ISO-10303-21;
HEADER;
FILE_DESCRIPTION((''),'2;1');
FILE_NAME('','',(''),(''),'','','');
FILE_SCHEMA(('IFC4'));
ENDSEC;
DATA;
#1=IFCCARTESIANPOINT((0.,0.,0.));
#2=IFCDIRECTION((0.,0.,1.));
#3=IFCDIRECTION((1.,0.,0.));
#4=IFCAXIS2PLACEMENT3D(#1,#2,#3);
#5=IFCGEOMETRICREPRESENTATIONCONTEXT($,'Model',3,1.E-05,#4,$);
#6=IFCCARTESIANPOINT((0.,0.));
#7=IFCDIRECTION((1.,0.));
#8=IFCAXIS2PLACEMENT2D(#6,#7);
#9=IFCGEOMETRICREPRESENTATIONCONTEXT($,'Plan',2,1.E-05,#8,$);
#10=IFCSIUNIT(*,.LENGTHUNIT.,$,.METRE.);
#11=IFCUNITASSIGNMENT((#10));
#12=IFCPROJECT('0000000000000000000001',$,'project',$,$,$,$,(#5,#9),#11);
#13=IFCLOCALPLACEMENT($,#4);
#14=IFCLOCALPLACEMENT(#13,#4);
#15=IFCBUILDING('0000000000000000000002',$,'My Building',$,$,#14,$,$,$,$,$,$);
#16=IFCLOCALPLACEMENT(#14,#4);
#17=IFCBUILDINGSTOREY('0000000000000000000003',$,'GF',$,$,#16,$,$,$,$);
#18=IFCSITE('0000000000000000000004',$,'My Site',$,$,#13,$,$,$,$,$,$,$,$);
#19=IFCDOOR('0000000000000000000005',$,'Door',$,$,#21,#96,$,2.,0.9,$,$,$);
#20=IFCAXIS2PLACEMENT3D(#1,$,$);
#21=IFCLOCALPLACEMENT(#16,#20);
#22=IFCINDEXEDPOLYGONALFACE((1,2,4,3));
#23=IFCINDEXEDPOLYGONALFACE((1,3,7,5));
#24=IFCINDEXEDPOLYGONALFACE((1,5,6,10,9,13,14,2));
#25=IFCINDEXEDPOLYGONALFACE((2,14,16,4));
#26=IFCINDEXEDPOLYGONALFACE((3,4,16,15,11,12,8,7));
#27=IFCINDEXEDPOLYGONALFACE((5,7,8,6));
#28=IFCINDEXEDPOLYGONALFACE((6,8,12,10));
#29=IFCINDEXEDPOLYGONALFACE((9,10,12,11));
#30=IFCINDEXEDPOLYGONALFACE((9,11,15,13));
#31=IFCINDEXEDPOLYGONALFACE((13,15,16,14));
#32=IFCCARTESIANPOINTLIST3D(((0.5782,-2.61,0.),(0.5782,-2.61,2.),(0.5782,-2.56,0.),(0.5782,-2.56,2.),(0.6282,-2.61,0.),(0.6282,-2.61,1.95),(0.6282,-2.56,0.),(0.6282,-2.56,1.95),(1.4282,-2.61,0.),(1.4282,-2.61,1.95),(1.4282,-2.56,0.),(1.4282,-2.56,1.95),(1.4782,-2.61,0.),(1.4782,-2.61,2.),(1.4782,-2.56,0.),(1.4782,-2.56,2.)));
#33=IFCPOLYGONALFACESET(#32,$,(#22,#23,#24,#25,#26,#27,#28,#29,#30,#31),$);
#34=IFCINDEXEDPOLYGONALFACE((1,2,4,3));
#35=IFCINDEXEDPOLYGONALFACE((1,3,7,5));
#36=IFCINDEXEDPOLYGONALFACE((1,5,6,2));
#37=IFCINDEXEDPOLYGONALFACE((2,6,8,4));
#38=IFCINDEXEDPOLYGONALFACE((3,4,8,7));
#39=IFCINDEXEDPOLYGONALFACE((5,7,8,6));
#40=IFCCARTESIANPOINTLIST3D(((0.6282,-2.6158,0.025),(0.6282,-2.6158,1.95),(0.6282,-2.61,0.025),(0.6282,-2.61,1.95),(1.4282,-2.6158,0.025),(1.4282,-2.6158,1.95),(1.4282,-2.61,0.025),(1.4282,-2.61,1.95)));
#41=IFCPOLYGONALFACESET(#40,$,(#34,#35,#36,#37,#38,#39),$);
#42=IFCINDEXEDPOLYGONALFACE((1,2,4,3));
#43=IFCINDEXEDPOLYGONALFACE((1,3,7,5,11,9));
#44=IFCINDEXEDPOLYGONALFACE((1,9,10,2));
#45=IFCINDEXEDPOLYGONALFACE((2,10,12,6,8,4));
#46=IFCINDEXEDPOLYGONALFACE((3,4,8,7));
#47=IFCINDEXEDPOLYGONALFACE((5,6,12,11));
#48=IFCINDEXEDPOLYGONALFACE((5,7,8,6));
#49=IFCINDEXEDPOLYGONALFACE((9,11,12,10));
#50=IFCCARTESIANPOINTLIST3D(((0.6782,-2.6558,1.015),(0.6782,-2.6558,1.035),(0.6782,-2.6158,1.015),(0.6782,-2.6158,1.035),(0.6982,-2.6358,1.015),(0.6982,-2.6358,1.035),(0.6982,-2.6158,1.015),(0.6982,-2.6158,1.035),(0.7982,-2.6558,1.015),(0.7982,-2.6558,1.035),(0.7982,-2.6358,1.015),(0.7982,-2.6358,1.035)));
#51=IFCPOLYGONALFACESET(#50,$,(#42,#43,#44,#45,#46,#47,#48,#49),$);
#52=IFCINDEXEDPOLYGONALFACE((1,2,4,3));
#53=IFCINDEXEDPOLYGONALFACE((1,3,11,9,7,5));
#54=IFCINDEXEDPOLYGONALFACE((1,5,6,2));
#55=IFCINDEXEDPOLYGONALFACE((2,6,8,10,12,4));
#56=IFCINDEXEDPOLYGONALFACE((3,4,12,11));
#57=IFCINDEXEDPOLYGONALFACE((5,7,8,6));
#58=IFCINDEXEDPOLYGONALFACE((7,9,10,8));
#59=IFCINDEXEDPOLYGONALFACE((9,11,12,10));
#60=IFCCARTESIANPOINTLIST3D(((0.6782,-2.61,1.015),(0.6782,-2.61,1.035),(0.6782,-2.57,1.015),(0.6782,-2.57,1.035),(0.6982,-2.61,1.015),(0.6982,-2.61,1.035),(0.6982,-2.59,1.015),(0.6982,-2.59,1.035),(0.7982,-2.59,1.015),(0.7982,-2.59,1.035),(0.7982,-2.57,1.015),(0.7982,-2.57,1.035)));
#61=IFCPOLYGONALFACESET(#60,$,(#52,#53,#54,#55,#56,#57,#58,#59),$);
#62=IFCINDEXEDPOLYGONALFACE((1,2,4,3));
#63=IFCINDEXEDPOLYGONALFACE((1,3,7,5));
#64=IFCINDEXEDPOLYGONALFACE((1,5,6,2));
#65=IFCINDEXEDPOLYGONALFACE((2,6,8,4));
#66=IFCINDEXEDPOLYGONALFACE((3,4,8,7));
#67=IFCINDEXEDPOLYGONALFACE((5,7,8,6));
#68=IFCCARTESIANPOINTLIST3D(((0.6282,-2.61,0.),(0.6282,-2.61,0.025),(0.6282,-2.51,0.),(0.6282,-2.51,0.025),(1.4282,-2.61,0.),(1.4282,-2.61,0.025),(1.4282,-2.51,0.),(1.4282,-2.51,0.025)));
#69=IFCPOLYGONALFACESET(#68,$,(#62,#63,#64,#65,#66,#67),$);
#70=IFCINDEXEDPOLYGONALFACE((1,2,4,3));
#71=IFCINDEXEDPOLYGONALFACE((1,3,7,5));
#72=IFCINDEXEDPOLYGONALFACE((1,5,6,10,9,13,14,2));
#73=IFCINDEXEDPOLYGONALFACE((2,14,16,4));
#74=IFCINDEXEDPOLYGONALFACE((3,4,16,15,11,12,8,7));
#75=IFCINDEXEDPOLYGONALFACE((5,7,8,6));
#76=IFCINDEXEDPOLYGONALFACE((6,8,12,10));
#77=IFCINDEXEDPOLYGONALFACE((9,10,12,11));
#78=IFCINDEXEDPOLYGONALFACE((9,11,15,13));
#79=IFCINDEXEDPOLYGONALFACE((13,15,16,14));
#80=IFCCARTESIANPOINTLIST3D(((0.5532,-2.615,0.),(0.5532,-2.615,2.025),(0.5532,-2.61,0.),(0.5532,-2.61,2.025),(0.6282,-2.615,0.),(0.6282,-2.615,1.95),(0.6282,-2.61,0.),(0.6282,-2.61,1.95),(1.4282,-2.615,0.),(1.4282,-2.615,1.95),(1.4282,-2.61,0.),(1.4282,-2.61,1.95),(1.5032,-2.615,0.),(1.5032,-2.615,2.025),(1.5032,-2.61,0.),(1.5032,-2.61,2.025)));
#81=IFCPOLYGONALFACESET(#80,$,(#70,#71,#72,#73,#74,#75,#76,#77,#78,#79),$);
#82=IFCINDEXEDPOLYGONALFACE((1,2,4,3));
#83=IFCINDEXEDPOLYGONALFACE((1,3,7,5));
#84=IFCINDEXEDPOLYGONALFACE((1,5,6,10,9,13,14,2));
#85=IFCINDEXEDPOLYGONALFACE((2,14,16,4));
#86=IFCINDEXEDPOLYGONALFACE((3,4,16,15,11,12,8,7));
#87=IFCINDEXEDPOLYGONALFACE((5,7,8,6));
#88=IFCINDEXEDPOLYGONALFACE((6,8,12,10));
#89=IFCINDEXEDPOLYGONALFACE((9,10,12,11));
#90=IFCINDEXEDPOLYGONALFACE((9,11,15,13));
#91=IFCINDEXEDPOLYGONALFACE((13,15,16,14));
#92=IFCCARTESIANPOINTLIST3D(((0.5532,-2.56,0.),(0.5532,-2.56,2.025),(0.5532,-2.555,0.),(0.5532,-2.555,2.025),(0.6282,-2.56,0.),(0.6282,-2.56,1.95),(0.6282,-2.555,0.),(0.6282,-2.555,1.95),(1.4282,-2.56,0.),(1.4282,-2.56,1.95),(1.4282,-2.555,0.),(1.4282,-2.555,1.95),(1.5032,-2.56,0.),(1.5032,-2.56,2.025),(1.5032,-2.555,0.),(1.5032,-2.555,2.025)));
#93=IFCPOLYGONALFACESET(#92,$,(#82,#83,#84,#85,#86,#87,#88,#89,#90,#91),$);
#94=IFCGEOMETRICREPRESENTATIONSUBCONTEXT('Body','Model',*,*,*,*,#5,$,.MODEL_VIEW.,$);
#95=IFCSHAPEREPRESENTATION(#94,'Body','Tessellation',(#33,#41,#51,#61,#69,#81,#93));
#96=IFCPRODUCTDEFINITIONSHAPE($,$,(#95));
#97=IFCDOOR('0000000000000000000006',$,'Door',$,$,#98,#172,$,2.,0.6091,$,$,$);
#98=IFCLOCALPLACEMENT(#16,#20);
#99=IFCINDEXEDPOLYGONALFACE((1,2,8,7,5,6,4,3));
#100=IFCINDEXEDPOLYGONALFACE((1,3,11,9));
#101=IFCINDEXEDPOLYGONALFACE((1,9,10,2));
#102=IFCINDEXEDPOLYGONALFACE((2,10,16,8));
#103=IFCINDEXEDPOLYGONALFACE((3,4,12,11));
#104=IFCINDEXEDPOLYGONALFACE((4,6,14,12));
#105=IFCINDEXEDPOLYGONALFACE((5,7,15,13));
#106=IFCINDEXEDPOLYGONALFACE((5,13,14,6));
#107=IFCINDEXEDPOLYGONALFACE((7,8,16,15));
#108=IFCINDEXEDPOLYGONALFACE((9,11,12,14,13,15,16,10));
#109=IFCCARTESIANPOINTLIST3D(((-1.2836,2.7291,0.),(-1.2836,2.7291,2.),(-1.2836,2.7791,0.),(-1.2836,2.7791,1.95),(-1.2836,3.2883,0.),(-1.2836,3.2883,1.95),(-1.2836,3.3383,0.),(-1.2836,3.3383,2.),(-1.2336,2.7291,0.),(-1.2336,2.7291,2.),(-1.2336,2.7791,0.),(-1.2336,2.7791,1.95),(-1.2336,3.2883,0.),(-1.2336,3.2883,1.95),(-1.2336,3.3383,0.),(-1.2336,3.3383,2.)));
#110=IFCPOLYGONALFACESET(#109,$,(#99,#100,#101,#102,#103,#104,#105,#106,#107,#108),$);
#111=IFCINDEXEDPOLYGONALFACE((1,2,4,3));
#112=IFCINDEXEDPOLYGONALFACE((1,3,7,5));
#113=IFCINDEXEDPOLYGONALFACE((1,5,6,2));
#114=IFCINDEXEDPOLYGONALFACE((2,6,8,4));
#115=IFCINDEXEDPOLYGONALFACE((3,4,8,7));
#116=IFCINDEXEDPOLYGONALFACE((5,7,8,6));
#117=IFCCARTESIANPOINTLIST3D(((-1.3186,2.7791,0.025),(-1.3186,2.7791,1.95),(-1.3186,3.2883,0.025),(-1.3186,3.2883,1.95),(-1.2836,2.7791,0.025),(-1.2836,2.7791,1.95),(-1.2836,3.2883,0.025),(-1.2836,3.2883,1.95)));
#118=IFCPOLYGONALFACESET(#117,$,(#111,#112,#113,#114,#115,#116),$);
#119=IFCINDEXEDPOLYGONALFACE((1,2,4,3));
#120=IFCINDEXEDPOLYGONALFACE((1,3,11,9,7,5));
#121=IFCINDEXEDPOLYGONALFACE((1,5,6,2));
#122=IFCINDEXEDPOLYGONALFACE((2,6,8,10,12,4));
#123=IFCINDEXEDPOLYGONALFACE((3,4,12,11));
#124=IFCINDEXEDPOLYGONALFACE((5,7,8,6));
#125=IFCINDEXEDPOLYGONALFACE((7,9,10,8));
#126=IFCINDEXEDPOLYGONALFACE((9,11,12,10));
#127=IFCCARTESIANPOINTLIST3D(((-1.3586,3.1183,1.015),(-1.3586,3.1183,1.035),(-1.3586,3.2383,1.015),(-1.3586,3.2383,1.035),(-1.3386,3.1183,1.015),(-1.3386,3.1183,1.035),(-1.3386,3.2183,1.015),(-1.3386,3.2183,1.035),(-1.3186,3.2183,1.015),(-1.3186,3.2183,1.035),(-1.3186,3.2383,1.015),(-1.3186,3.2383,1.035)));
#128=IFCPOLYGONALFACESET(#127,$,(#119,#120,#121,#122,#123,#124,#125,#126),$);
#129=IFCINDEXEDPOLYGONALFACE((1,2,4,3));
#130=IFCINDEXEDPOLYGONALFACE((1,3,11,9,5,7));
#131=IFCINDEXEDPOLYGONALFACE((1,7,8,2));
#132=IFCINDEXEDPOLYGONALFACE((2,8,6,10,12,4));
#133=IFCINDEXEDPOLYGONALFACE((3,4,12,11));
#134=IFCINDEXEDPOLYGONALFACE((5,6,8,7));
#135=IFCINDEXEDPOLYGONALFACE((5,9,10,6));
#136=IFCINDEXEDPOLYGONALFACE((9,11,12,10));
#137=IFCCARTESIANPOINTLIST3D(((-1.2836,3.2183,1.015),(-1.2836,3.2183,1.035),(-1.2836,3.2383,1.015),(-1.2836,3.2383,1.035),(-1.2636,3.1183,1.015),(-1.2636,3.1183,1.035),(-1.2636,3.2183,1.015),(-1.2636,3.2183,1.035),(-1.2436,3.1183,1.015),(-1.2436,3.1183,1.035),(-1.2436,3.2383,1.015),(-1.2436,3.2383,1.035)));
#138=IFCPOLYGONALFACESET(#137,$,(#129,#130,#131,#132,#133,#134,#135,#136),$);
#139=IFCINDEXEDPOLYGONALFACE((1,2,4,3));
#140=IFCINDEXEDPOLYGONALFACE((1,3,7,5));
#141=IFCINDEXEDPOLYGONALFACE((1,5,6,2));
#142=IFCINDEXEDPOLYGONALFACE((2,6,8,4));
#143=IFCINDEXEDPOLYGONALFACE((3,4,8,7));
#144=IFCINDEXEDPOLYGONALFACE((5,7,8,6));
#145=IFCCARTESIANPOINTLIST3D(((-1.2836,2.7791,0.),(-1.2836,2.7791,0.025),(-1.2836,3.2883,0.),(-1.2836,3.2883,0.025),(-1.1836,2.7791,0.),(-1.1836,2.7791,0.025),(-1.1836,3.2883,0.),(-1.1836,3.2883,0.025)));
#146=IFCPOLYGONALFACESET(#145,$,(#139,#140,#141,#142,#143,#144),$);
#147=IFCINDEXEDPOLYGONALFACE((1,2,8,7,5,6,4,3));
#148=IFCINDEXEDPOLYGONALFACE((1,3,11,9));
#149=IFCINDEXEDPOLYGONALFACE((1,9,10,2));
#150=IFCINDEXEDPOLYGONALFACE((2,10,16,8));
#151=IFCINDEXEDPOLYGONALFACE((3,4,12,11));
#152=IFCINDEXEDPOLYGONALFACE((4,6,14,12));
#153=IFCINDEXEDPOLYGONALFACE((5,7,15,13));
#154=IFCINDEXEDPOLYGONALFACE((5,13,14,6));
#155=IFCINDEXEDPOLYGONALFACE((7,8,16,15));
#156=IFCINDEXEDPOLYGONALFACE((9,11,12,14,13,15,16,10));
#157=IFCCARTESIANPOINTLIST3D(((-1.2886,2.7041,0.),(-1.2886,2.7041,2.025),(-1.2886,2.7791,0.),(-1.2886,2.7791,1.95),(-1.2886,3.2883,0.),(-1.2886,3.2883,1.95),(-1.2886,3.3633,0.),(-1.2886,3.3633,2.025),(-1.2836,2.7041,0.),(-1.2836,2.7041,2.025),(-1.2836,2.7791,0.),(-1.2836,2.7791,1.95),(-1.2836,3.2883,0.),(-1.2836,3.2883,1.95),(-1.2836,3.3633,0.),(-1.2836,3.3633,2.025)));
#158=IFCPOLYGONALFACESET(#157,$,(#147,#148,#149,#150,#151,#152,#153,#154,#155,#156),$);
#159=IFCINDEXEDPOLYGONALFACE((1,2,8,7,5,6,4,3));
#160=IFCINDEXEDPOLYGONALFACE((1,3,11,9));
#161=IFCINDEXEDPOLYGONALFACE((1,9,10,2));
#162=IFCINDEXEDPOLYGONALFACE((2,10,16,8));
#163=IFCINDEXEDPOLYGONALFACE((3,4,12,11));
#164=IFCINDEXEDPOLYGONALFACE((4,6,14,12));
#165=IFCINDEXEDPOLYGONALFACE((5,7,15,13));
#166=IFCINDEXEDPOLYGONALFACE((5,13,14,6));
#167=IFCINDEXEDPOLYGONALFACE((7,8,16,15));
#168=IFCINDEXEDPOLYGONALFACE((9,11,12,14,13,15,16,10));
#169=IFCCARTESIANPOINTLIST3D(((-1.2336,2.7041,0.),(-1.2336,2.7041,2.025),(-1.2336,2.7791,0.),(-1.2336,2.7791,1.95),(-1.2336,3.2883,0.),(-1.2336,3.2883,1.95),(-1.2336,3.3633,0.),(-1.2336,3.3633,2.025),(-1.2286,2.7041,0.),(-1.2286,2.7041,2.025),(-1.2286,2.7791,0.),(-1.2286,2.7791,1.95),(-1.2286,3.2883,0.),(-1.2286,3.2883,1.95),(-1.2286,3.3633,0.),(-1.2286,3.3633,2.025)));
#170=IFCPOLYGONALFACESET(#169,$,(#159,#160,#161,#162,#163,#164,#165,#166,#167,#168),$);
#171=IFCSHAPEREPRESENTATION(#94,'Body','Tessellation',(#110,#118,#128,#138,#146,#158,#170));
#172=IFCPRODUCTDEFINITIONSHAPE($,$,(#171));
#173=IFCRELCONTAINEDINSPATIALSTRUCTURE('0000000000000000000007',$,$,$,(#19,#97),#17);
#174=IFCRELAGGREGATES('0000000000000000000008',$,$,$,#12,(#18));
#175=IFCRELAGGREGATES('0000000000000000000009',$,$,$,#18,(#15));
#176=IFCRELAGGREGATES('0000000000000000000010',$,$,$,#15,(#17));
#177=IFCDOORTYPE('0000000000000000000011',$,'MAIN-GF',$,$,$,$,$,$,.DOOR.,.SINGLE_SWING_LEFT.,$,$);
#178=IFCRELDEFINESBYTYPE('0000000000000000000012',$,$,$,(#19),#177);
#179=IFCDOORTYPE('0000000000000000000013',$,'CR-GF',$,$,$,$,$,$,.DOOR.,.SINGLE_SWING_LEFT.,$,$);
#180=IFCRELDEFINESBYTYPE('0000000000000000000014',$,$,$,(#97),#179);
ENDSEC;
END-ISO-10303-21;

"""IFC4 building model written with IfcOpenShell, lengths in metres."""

from ifc_helpers import new_model, entity, si_unit, frame, origin_with_axes, origin_2d_with_axis, place, context, subcontext, project, spatial, line, indexed_curve, outline, extrude, shape, source, transform, mapped, type_object, type_shapes, element, save


model = new_model("IFC4")

# Units and contexts
model_context = context("Model", 3, precision=1e-05, world=origin_with_axes())
plan_context = context("Plan", 2, precision=1e-05, world=origin_2d_with_axis())
body_context_1 = subcontext(model_context, "Body", "Model", "MODEL_VIEW")
body_context_2 = subcontext(plan_context, "Body", "Plan", "PLAN_VIEW")
ifc_project = project(units=[si_unit("LENGTHUNIT", "METRE")], contexts=[model_context, plan_context])

# Site, building, storey
site_placement = place(None, origin_with_axes())
site = spatial("IfcSite", under=ifc_project, at=site_placement, Name="My Site")
building_placement = place(site_placement, origin_with_axes())
building = spatial("IfcBuilding", under=site, at=building_placement, Name="My Building")
storey_placement = place(building_placement, origin_with_axes())
storey = spatial("IfcBuildingStorey", under=building, at=storey_placement, Name="GF")

# Shared definitions
wall_1_placement = place(storey_placement, frame((0.2283, -2.61, 0.0), z_axis=(0.0, 0.0, 1.0), x_axis=(1.0, 0.0, 0.0)))
door_type_1 = type_object("IfcDoorType", Name="MAIN-GF", OperationType="SINGLE_SWING_LEFT", PredefinedType="DOOR")
shared_shape_1 = source(origin_with_axes(), body_context_1, "Body", "SweptSolid", [
    extrude(outline(indexed_curve([(0.0, 0.0), (0.0, 2.0), (0.9, 2.0), (0.9, 0.0), (0.85, 0.0), (0.85, 1.95), (0.05, 1.95), (0.05, 0.0)], segments=[line(1, 2, 3, 4, 5, 6, 7, 8, 1)])), frame((0.0, 0.0, 0.0), z_axis=(0.0, -1.0, 0.0), x_axis=(1.0, 0.0, 0.0)), (0.0, 0.0, -1.0), 0.05),
    extrude(outline(indexed_curve([(0.0, 0.0), (0.8, 0.0), (0.8, 0.0058), (0.0, 0.0058)], segments=[line(1, 2, 3, 4, 1)])), frame((0.05, -0.0058, 0.025), z_axis=(0.0, 0.0, 1.0), x_axis=(1.0, 0.0, 0.0)), (0.0, 0.0, 1.0), 1.925),
    extrude(outline(indexed_curve([(0.0, 0.0), (0.0, -0.04), (0.12, -0.04), (0.12, -0.02), (0.02, -0.02), (0.02, 0.0)], segments=[line(1, 2, 3, 4, 5, 6, 1)])), frame((0.1, -0.0058, 1.015), z_axis=(0.0, 0.0, 1.0), x_axis=(1.0, 0.0, 0.0)), (0.0, 0.0, 1.0), 0.02),
    extrude(outline(indexed_curve([(0.0, 0.0), (0.0, 0.04), (0.12, 0.04), (0.12, 0.02), (0.02, 0.02), (0.02, 0.0)], segments=[line(1, 2, 3, 4, 5, 6, 1)])), frame((0.1, 0.0, 1.015), z_axis=(0.0, 0.0, 1.0), x_axis=(1.0, 0.0, 0.0)), (0.0, 0.0, 1.0), 0.02),
    extrude(outline(indexed_curve([(0.0, 0.0), (0.8, 0.0), (0.8, 0.1), (0.0, 0.1)], segments=[line(1, 2, 3, 4, 1)])), frame((0.05, 0.0, 0.0), z_axis=(0.0, 0.0, 1.0), x_axis=(1.0, 0.0, 0.0)), (0.0, 0.0, 1.0), 0.025),
    extrude(outline(indexed_curve([(0.0, 0.0), (0.0, 2.025), (0.95, 2.025), (0.95, 0.0), (0.875, 0.0), (0.875, 1.95), (0.075, 1.95), (0.075, 0.0)], segments=[line(1, 2, 3, 4, 5, 6, 7, 8, 1)])), frame((-0.025, -0.005, 0.0), z_axis=(0.0, -1.0, 0.0), x_axis=(1.0, 0.0, 0.0)), (0.0, 0.0, -1.0), 0.005),
    extrude(outline(indexed_curve([(0.0, 0.0), (0.0, 2.025), (0.95, 2.025), (0.95, 0.0), (0.875, 0.0), (0.875, 1.95), (0.075, 1.95), (0.075, 0.0)], segments=[line(1, 2, 3, 4, 5, 6, 7, 8, 1)])), frame((-0.025, 0.05, 0.0), z_axis=(0.0, -1.0, 0.0), x_axis=(1.0, 0.0, 0.0)), (0.0, 0.0, -1.0), 0.005),
])
shared_shape_2 = source(origin_with_axes(), body_context_2, "Body", "Curve2D", [
    entity("IfcIndexedPolyCurve", entity("IfcCartesianPointList2D", [[0.0, 0.0], [0.05, 0.0], [0.05, 0.05], [0.0, 0.05]]), [entity("IfcLineIndex", [1, 2, 3, 4, 1])]),
    entity("IfcIndexedPolyCurve", entity("IfcCartesianPointList2D", [[0.9, 0.0], [0.85, 0.0], [0.85, 0.05], [0.9, 0.05]]), [entity("IfcLineIndex", [1, 2, 3, 4, 1])]),
    entity("IfcIndexedPolyCurve", entity("IfcCartesianPointList2D", [[1.25, -0.0058], [0.45, -0.0058], [0.45, 0.0], [1.25, 0.0]]), [entity("IfcLineIndex", [1, 2, 3, 4, 1])]),
])
type_shapes(door_type_1, [shared_shape_1, shared_shape_2])

# Shared definitions
wall_2_placement = place(storey_placement, frame((-1.1836, 2.64, 0.0), z_axis=(0.0, 0.0, 1.0), x_axis=(0.0, 1.0, 0.0)))
door_type_2 = type_object("IfcDoorType", Name="CR-GF", OperationType="SINGLE_SWING_LEFT", PredefinedType="DOOR")
shared_shape_3 = source(origin_with_axes(), body_context_1, "Body", "SweptSolid", [
    extrude(outline(indexed_curve([(0.0, 0.0), (0.0, 2.0), (0.6091, 2.0), (0.6091, 0.0), (0.5591, 0.0), (0.5591, 1.95), (0.05, 1.95), (0.05, 0.0)], segments=[line(1, 2, 3, 4, 5, 6, 7, 8, 1)])), frame((0.0, 0.0, 0.0), z_axis=(0.0, -1.0, 0.0), x_axis=(1.0, 0.0, 0.0)), (0.0, 0.0, -1.0), 0.05),
    extrude(outline(indexed_curve([(0.0, 0.0), (0.5091, 0.0), (0.5091, 0.035), (0.0, 0.035)], segments=[line(1, 2, 3, 4, 1)])), frame((0.05, -0.035, 0.025), z_axis=(0.0, 0.0, 1.0), x_axis=(1.0, 0.0, 0.0)), (0.0, 0.0, 1.0), 1.925),
    extrude(outline(indexed_curve([(0.0, 0.0), (0.0, -0.04), (0.12, -0.04), (0.12, -0.02), (0.02, -0.02), (0.02, 0.0)], segments=[line(1, 2, 3, 4, 5, 6, 1)])), frame((0.1, -0.035, 1.015), z_axis=(0.0, 0.0, 1.0), x_axis=(1.0, 0.0, 0.0)), (0.0, 0.0, 1.0), 0.02),
    extrude(outline(indexed_curve([(0.0, 0.0), (0.0, 0.04), (0.12, 0.04), (0.12, 0.02), (0.02, 0.02), (0.02, 0.0)], segments=[line(1, 2, 3, 4, 5, 6, 1)])), frame((0.1, 0.0, 1.015), z_axis=(0.0, 0.0, 1.0), x_axis=(1.0, 0.0, 0.0)), (0.0, 0.0, 1.0), 0.02),
    extrude(outline(indexed_curve([(0.0, 0.0), (0.5091, 0.0), (0.5091, 0.1), (0.0, 0.1)], segments=[line(1, 2, 3, 4, 1)])), frame((0.05, 0.0, 0.0), z_axis=(0.0, 0.0, 1.0), x_axis=(1.0, 0.0, 0.0)), (0.0, 0.0, 1.0), 0.025),
    extrude(outline(indexed_curve([(0.0, 0.0), (0.0, 2.025), (0.6591, 2.025), (0.6591, 0.0), (0.5841, 0.0), (0.5841, 1.95), (0.075, 1.95), (0.075, 0.0)], segments=[line(1, 2, 3, 4, 5, 6, 7, 8, 1)])), frame((-0.025, -0.005, 0.0), z_axis=(0.0, -1.0, 0.0), x_axis=(1.0, 0.0, 0.0)), (0.0, 0.0, -1.0), 0.005),
    extrude(outline(indexed_curve([(0.0, 0.0), (0.0, 2.025), (0.6591, 2.025), (0.6591, 0.0), (0.5841, 0.0), (0.5841, 1.95), (0.075, 1.95), (0.075, 0.0)], segments=[line(1, 2, 3, 4, 5, 6, 7, 8, 1)])), frame((-0.025, 0.05, 0.0), z_axis=(0.0, -1.0, 0.0), x_axis=(1.0, 0.0, 0.0)), (0.0, 0.0, -1.0), 0.005),
])
shared_shape_4 = source(origin_with_axes(), body_context_2, "Body", "Curve2D", [
    entity("IfcIndexedPolyCurve", entity("IfcCartesianPointList2D", [[0.0, 0.0], [0.05, 0.0], [0.05, 0.05], [0.0, 0.05]]), [entity("IfcLineIndex", [1, 2, 3, 4, 1])]),
    entity("IfcIndexedPolyCurve", entity("IfcCartesianPointList2D", [[0.6091, 0.0], [0.5591, 0.0], [0.5591, 0.05], [0.6091, 0.05]]), [entity("IfcLineIndex", [1, 2, 3, 4, 1])]),
    entity("IfcIndexedPolyCurve", entity("IfcCartesianPointList2D", [[0.8137, -0.035], [0.3046, -0.035], [0.3046, 0.0], [0.8137, 0.0]]), [entity("IfcLineIndex", [1, 2, 3, 4, 1])]),
])
type_shapes(door_type_2, [shared_shape_3, shared_shape_4])

# Doors
placement_1 = place(wall_1_placement, frame((0.3499, 0.0, 0.0), z_axis=(0.0, 0.0, 1.0), x_axis=(1.0, 0.0, 0.0)))
door_1_placement = place(placement_1, origin_with_axes())
element("IfcDoor", 1, at=door_1_placement, inside=storey, type_object=door_type_1, Name="Door", OverallHeight=2.0, OverallWidth=0.9, shapes=[
    shape(body_context_1, "Body", "MappedRepresentation", [mapped(shared_shape_1, transform((0.0, 0.0, 0.0), x_axis=(1.0, 0.0, 0.0), y_axis=(0.0, 1.0, 0.0), z_axis=(0.0, 0.0, 1.0), scale=1.0))]),
    shape(body_context_2, "Body", "MappedRepresentation", [mapped(shared_shape_2, transform((0.0, 0.0, 0.0), x_axis=(1.0, 0.0, 0.0), y_axis=(0.0, 1.0, 0.0), z_axis=(0.0, 0.0, 1.0), scale=1.0))]),
])
placement_2 = place(wall_2_placement, frame((0.6983, 0.1, 0.0), z_axis=(0.0, 0.0, 1.0), x_axis=(-1.0, 0.0, 0.0)))
door_2_placement = place(placement_2, frame((0.0, 0.0, 0.0), z_axis=(0.0, 0.0, 1.0), x_axis=(1.0, 0.0, 0.0)))
element("IfcDoor", 2, at=door_2_placement, inside=storey, type_object=door_type_2, Name="Door", OverallHeight=2.0, OverallWidth=0.6091, shapes=[
    shape(body_context_1, "Body", "MappedRepresentation", [mapped(shared_shape_3, transform((0.0, 0.0, 0.0), x_axis=(1.0, 0.0, 0.0), y_axis=(0.0, 1.0, 0.0), z_axis=(0.0, 0.0, 1.0), scale=1.0))]),
    shape(body_context_2, "Body", "MappedRepresentation", [mapped(shared_shape_4, transform((0.0, 0.0, 0.0), x_axis=(1.0, 0.0, 0.0), y_axis=(0.0, 1.0, 0.0), z_axis=(0.0, 0.0, 1.0), scale=1.0))]),
])

save(model, "model.ifc")
